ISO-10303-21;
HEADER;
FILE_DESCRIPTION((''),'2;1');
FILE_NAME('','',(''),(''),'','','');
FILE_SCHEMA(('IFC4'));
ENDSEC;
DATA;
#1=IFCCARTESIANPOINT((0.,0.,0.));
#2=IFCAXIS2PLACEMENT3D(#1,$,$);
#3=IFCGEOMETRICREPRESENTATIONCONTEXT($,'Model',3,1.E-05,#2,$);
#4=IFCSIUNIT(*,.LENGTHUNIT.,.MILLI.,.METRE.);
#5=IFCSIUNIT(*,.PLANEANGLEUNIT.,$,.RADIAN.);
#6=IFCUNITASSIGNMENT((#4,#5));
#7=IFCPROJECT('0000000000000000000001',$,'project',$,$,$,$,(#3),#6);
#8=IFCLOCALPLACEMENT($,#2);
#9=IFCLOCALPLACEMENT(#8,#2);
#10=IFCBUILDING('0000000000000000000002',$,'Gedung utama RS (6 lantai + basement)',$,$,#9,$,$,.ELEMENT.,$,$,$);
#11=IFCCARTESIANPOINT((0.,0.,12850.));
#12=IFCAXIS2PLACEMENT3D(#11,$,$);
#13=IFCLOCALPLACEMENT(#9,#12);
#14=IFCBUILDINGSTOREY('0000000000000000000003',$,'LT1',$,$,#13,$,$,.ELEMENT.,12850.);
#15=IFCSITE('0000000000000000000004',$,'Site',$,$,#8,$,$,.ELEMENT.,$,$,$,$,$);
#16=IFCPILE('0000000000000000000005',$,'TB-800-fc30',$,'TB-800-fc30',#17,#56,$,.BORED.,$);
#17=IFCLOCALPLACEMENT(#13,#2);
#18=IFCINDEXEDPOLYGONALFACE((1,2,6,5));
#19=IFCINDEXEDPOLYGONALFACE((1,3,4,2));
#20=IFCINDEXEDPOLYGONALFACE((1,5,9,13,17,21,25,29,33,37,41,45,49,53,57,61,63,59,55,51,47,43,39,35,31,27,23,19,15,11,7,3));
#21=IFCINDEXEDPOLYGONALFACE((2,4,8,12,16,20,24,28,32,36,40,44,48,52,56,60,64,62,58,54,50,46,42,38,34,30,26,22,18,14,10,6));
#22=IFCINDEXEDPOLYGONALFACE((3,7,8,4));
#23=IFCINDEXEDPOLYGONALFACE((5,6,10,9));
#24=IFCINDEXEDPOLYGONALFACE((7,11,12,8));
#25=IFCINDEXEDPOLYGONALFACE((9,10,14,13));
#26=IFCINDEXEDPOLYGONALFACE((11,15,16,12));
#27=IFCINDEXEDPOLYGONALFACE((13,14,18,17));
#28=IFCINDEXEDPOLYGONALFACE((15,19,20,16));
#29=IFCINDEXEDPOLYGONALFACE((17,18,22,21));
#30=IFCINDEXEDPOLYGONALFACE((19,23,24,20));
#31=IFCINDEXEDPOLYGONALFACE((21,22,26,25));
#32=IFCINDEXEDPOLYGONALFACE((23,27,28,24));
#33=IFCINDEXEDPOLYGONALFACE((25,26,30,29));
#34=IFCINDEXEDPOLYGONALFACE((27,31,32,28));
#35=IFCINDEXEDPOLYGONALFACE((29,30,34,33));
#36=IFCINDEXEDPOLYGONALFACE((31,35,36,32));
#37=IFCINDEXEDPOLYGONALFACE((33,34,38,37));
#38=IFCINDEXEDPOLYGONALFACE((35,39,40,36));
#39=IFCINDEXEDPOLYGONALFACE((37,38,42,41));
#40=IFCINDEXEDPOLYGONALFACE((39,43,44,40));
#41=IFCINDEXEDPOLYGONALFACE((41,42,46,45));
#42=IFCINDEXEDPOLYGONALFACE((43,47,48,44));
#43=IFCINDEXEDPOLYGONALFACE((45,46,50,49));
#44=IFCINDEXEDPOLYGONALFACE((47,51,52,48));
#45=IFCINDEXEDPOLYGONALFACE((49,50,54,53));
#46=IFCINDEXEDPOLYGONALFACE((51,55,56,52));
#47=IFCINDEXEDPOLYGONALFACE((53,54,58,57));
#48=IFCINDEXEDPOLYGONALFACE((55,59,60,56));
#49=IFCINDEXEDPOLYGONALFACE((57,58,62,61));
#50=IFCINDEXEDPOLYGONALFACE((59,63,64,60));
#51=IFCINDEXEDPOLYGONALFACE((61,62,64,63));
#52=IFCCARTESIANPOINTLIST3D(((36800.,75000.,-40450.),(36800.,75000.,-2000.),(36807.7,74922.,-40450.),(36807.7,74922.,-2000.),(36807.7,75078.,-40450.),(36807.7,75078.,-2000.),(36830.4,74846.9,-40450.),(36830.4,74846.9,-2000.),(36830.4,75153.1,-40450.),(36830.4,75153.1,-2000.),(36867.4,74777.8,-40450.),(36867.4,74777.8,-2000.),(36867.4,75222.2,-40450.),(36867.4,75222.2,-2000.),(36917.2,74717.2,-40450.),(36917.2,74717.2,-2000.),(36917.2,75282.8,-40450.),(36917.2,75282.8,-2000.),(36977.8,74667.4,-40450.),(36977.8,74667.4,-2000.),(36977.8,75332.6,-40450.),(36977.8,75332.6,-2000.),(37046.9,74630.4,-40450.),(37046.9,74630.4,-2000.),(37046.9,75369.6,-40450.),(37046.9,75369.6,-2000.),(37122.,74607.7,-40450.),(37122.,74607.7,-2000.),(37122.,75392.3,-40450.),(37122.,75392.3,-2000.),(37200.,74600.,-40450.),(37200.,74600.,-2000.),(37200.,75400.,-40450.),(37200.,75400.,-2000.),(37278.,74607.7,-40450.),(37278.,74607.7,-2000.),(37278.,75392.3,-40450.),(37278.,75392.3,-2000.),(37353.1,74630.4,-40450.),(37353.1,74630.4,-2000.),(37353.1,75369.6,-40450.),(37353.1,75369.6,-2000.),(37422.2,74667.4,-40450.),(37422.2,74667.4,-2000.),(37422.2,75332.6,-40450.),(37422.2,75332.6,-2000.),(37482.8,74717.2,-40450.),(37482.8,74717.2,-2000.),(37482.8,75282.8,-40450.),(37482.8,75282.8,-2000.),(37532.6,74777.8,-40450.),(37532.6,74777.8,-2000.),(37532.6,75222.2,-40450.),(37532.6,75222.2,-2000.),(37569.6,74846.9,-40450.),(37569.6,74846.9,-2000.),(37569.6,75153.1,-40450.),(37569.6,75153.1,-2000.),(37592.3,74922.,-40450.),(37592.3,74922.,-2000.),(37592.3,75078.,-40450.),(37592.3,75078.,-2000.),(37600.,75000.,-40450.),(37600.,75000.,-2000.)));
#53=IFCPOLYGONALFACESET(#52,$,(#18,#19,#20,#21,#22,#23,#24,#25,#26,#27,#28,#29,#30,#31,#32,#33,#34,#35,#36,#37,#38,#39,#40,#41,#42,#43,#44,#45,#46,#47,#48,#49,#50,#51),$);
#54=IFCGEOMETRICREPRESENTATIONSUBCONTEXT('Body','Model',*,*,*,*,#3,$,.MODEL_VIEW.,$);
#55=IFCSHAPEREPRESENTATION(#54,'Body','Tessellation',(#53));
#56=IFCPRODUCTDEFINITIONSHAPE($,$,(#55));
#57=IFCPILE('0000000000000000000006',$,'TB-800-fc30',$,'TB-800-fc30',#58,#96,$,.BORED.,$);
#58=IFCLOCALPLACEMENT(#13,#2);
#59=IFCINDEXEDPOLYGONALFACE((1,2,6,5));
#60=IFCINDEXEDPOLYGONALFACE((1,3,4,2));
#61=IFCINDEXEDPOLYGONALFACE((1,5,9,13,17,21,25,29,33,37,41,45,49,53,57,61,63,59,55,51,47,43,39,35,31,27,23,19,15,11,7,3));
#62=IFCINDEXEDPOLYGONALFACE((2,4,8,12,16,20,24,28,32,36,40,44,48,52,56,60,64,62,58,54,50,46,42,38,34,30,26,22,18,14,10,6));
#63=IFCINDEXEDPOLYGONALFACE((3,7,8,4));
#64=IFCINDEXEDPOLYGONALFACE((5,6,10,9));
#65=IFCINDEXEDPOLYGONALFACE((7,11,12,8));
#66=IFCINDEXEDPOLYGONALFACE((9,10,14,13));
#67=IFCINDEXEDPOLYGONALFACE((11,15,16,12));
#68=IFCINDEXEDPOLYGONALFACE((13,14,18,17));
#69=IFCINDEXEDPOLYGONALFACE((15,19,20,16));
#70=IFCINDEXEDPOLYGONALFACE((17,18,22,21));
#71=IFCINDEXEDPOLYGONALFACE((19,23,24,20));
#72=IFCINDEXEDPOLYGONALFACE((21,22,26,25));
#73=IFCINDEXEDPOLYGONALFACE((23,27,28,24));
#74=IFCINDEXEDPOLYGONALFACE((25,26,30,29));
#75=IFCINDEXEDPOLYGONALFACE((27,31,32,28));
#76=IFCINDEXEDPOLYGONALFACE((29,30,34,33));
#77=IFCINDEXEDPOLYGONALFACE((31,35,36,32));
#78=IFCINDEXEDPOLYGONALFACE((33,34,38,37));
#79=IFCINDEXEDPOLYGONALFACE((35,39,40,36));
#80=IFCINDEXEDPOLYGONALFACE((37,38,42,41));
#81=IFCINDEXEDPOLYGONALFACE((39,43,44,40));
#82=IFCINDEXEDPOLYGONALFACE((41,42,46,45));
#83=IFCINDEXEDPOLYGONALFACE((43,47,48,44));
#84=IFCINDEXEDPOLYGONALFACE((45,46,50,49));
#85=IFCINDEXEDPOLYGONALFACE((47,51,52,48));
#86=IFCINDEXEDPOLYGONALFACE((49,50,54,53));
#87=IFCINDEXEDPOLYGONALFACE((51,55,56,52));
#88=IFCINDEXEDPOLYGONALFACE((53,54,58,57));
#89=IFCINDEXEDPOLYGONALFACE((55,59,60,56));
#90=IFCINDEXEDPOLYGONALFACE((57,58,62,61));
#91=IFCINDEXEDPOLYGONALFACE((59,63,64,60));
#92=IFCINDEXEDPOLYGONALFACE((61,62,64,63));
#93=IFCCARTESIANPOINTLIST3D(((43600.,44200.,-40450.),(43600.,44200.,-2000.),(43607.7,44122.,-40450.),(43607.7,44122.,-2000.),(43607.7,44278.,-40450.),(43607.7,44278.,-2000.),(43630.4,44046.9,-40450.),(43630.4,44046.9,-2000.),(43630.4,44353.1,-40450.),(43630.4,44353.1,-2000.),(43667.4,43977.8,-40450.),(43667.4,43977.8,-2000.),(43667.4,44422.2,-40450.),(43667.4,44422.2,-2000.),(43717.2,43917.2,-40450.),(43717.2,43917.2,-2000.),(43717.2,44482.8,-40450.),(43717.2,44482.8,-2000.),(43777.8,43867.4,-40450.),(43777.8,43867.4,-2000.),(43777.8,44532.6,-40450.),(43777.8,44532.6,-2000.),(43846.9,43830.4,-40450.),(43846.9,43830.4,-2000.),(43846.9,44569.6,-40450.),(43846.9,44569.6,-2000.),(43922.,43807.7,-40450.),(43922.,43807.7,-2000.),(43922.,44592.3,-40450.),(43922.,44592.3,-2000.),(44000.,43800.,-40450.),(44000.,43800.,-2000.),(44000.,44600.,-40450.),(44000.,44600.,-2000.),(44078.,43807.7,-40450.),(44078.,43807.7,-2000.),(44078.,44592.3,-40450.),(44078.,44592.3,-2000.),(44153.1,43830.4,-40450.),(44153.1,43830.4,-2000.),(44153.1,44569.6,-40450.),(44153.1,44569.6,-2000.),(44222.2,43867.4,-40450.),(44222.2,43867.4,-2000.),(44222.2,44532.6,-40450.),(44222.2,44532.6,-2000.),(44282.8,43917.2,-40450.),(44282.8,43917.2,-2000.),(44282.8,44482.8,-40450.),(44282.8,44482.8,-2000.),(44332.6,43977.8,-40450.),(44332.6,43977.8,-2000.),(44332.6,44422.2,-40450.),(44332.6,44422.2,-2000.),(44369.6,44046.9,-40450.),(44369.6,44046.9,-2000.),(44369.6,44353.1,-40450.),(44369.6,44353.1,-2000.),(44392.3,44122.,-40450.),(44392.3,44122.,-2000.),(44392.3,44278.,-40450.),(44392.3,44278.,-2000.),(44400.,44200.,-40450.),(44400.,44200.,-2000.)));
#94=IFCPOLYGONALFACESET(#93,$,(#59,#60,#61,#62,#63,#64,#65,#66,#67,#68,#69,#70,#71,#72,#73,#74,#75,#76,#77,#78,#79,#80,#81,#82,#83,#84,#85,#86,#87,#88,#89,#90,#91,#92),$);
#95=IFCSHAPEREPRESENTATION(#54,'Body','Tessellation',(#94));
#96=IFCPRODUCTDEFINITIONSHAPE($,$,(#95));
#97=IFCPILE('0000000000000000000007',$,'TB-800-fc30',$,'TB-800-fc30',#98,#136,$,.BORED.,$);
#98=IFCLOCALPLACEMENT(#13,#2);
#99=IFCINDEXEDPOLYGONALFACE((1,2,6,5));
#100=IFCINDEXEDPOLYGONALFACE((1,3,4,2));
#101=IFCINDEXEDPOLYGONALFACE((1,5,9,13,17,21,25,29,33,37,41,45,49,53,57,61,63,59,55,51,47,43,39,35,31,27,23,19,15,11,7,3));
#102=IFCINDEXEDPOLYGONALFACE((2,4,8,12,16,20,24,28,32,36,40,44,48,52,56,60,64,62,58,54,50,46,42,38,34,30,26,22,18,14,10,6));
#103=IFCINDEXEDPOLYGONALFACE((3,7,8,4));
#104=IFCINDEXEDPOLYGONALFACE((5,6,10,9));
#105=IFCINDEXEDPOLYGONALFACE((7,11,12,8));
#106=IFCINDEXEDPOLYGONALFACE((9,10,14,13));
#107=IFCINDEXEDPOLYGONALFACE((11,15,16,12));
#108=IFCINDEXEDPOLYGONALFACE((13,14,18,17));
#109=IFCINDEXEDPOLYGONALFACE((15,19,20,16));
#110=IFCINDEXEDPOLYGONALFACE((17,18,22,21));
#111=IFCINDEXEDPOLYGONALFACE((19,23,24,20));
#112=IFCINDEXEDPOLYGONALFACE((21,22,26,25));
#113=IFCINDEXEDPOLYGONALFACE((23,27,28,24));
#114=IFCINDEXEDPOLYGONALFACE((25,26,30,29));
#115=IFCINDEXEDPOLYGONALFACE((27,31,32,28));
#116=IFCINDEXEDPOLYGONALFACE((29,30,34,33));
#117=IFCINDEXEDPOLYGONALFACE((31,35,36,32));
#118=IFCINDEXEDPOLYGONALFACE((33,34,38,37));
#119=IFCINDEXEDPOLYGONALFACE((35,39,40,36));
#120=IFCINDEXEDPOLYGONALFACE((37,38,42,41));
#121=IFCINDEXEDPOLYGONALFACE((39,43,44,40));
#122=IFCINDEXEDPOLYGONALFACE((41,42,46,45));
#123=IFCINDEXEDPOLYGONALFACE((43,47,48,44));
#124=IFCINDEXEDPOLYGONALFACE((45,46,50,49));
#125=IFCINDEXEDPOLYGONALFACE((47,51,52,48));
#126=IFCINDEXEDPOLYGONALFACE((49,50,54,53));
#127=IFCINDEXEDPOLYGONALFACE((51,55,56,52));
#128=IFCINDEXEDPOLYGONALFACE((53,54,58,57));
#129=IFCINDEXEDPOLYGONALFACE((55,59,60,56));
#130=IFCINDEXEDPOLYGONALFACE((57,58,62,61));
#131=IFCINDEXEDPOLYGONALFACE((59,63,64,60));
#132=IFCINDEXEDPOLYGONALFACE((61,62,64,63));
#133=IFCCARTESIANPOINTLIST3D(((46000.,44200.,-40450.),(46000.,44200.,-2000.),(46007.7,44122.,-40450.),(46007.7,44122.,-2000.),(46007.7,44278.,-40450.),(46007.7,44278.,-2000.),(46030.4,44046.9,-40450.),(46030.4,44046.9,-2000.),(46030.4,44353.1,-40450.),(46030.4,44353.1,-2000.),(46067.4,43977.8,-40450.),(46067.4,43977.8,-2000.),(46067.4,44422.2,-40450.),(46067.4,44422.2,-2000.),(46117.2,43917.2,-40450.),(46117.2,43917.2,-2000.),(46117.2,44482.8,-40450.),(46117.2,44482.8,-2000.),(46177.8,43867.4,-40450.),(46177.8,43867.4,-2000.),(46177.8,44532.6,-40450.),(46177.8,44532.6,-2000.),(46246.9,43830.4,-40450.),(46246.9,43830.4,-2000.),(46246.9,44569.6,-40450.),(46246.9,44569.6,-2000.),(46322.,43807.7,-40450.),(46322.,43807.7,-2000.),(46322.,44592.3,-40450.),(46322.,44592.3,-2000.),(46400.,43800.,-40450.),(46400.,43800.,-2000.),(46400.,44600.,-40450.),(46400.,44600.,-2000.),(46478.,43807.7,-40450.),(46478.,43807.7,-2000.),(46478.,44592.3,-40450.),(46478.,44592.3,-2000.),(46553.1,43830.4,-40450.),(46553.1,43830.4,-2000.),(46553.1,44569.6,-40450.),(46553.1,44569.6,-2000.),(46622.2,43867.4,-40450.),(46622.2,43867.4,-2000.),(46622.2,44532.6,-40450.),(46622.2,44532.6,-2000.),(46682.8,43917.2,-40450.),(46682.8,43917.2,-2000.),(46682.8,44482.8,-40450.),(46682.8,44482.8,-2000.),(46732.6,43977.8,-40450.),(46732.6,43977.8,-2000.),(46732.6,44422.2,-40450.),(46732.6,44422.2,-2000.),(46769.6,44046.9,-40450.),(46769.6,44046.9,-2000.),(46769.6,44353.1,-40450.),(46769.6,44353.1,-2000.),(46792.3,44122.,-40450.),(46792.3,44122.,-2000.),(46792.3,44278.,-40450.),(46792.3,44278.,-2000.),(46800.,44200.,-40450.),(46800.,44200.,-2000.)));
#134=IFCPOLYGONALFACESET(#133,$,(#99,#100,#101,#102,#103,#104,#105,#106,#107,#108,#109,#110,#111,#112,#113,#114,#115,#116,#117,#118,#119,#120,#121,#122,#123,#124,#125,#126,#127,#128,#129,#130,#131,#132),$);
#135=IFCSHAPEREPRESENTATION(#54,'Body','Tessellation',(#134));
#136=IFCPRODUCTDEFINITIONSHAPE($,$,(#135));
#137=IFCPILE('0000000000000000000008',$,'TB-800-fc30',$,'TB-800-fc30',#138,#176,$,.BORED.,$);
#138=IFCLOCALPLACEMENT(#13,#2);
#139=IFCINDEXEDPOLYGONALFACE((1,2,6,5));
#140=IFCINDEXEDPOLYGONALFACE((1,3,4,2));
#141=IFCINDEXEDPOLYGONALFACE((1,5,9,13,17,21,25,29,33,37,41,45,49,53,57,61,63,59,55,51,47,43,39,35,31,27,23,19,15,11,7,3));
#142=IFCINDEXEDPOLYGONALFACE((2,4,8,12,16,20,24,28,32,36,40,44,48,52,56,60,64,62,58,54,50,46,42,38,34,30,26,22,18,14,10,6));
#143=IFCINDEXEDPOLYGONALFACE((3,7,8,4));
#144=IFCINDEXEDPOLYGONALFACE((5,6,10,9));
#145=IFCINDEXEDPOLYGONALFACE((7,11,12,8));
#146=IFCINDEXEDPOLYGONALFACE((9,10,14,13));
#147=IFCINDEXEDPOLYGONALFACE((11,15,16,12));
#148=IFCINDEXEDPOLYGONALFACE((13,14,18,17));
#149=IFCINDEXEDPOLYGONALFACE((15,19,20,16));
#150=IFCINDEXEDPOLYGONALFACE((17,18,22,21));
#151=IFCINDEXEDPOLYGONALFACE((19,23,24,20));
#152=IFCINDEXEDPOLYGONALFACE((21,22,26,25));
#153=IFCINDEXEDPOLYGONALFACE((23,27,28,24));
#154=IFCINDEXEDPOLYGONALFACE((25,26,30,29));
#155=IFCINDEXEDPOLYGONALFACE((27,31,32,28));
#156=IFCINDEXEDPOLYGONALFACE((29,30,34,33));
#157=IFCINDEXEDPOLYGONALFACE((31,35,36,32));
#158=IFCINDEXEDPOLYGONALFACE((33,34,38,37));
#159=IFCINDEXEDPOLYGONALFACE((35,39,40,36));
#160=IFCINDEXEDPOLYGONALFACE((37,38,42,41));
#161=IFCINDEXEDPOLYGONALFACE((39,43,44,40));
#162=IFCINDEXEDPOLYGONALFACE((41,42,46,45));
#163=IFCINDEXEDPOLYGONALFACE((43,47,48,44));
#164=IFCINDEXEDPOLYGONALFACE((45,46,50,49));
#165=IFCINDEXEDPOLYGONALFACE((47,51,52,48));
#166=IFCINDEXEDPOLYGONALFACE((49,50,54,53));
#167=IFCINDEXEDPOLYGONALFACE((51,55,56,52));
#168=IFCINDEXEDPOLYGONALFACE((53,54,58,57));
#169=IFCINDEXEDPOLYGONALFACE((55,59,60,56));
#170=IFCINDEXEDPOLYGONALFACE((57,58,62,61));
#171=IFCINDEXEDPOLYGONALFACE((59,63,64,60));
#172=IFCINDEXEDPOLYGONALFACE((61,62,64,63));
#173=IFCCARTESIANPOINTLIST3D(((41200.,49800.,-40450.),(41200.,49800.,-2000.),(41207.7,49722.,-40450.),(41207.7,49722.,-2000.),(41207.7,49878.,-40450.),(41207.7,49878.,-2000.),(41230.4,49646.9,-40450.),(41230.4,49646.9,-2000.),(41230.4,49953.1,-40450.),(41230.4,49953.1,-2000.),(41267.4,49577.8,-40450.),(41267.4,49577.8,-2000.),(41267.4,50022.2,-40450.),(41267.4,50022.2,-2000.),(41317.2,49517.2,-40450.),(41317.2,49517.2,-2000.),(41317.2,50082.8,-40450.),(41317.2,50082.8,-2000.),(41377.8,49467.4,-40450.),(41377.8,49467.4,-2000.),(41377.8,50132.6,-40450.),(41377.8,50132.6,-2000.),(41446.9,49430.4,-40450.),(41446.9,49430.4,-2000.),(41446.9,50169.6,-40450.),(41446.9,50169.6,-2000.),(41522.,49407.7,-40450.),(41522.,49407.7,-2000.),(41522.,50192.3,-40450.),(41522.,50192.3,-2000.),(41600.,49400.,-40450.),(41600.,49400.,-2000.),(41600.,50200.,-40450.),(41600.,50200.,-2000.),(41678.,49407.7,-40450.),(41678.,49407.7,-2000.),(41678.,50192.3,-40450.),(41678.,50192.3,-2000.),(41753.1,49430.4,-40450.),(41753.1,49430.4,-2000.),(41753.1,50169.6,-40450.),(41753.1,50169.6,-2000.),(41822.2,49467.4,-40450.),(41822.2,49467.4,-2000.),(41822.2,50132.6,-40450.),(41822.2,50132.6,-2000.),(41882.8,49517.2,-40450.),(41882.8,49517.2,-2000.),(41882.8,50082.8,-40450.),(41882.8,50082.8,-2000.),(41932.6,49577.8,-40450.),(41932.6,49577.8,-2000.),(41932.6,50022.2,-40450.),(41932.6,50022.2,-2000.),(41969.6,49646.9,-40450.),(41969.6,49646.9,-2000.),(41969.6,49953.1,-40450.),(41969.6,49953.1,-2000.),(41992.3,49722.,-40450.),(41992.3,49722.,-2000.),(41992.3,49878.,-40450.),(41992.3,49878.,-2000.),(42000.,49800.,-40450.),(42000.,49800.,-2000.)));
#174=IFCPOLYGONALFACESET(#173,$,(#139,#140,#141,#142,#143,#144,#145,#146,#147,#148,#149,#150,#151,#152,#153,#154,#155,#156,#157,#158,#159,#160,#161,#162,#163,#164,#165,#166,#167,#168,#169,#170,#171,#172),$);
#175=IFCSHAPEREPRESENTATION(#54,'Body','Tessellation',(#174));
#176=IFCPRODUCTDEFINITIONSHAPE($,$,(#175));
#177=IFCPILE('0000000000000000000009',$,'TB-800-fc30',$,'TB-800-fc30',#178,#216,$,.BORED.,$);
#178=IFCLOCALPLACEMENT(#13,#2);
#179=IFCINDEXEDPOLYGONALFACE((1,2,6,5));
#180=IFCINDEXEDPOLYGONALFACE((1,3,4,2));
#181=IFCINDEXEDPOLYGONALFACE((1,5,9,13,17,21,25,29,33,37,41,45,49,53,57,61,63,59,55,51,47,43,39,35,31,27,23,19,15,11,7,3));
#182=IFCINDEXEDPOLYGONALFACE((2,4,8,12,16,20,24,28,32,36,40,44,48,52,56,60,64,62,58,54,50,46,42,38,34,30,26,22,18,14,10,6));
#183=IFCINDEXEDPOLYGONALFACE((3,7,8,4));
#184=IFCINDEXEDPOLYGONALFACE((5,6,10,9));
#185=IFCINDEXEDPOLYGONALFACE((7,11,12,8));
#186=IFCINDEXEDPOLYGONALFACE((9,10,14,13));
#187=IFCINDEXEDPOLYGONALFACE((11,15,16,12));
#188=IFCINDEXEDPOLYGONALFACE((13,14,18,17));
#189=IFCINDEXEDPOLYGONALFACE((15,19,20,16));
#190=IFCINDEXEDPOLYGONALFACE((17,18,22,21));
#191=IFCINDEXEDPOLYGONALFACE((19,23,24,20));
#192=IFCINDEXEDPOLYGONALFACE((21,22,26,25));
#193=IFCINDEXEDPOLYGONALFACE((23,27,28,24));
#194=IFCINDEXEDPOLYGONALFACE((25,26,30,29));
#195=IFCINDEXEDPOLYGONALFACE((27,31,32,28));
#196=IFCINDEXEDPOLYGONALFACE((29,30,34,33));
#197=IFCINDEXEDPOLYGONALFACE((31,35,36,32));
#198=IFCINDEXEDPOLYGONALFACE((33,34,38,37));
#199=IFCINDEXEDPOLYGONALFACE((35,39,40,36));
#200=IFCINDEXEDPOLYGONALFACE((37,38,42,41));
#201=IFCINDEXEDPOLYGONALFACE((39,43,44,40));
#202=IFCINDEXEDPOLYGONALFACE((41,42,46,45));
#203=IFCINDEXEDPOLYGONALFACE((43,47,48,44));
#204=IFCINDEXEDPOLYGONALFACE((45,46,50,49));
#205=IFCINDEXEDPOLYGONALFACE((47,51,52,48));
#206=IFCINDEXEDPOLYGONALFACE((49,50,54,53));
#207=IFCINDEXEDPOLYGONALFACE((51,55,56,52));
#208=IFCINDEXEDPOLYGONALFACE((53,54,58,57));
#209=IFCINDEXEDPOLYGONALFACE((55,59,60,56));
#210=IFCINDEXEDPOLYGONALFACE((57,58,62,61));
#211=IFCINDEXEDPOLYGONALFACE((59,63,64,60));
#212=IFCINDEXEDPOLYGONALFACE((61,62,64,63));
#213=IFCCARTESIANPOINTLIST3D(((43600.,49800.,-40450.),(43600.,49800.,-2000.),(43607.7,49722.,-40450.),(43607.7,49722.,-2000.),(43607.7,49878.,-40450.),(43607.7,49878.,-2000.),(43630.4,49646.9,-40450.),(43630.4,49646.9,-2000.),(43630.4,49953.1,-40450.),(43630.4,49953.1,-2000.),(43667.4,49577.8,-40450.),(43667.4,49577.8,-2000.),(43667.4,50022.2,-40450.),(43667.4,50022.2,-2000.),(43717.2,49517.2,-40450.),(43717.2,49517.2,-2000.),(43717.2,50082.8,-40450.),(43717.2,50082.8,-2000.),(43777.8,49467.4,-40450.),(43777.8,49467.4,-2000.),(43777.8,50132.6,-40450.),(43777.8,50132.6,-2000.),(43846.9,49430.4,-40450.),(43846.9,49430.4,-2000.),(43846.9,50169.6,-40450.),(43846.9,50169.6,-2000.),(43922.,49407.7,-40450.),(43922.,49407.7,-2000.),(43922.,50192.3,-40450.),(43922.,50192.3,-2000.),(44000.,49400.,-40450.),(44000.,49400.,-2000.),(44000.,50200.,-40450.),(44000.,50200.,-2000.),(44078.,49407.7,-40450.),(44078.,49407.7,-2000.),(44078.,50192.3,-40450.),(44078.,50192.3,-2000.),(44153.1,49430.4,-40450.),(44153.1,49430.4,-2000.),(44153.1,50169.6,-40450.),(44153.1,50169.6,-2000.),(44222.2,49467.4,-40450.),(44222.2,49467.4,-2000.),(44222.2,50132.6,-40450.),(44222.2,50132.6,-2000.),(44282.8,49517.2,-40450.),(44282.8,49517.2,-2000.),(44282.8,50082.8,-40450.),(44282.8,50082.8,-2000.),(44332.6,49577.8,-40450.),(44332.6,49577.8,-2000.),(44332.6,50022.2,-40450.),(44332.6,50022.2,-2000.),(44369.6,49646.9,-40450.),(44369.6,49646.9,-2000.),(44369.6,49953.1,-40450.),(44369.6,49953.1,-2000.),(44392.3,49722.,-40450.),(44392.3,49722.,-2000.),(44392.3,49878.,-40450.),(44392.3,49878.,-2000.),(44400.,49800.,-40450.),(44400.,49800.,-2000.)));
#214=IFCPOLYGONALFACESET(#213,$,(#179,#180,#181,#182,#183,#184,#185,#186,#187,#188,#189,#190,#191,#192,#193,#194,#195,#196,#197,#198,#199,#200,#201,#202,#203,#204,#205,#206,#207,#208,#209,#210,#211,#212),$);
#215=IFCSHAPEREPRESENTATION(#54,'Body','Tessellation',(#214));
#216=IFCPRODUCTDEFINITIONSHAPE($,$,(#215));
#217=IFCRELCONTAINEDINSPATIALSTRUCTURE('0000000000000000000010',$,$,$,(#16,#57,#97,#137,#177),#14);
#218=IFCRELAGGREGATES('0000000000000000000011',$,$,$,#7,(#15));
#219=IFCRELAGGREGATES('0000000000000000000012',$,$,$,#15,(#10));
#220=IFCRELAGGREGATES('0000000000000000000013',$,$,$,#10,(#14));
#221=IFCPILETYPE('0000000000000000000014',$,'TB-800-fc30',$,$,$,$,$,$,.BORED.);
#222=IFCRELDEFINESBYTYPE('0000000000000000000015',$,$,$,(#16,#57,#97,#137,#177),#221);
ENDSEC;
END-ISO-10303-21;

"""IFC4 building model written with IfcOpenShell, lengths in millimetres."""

from ifc_helpers import new_model, si_unit, frame, origin, origin_2d, place, context, subcontext, project, spatial, circle, extrude, material_profile, profile_set, profile_usage, type_object, element, save


model = new_model("IFC4")

# Units and contexts
model_context = context("Model", 3, precision=1e-05, world=origin())
body_context = subcontext(model_context, "Body", "Model", "MODEL_VIEW")
ifc_project = project(units=[si_unit("LENGTHUNIT", "METRE", prefix="MILLI"), si_unit("PLANEANGLEUNIT", "RADIAN")], contexts=[model_context])

# Site, building, storey
site_placement = place(None, origin())
site = spatial("IfcSite", under=ifc_project, at=site_placement, Name="Site", CompositionType="ELEMENT")
building_placement = place(site_placement, origin())
building = spatial("IfcBuilding", under=site, at=building_placement, Name="Gedung utama RS (6 lantai + basement)", CompositionType="ELEMENT")
storey_placement = place(building_placement, frame((0.0, 0.0, 12850.0)))
storey = spatial("IfcBuildingStorey", under=building, at=storey_placement, Name="LT1", CompositionType="ELEMENT", Elevation=12850.0)

# Piles
ifc_material_profile = material_profile(None, circle(Radius=400.0, at=origin_2d()), Name="TB-800-fc30")
ifc_profile_set = profile_set([ifc_material_profile], Name="TB-800-fc30")
ifc_profile_usage = profile_usage(ifc_profile_set, cardinal=5)
pile_type = type_object("IfcPileType", Name="TB-800-fc30", PredefinedType="BORED", material=ifc_profile_set)
for number, where, z_axis, x_axis, name in (
    (1, (37200.0, 75000.0, -40450.0), (0.0, 0.0, 1.0), (1.0, 0.0, 0.0), "TB-800-fc30"),
    (2, (44000.0, 44200.0, -40450.0), (0.0, 0.0, 1.0), (1.0, 0.0, 0.0), "TB-800-fc30"),
    (3, (46400.0, 44200.0, -40450.0), (0.0, 0.0, 1.0), (1.0, 0.0, 0.0), "TB-800-fc30"),
    (4, (41600.0, 49800.0, -40450.0), (0.0, 0.0, 1.0), (1.0, 0.0, 0.0), "TB-800-fc30"),
    (5, (44000.0, 49800.0, -40450.0), (0.0, 0.0, 1.0), (1.0, 0.0, 0.0), "TB-800-fc30"),
):
    element("IfcPile", number, at=place(storey_placement, frame(where, z_axis=z_axis, x_axis=x_axis)), inside=storey, type_object=pile_type, material=ifc_profile_usage, Name=name, ObjectType="TB-800-fc30", PredefinedType="BORED", context=body_context, shape_type="SweptSolid", body=[
        extrude(circle(Radius=400.0, at=origin_2d()), origin(), (0.0, 0.0, 1.0), 38450.0),
    ])

save(model, "model.ifc")
